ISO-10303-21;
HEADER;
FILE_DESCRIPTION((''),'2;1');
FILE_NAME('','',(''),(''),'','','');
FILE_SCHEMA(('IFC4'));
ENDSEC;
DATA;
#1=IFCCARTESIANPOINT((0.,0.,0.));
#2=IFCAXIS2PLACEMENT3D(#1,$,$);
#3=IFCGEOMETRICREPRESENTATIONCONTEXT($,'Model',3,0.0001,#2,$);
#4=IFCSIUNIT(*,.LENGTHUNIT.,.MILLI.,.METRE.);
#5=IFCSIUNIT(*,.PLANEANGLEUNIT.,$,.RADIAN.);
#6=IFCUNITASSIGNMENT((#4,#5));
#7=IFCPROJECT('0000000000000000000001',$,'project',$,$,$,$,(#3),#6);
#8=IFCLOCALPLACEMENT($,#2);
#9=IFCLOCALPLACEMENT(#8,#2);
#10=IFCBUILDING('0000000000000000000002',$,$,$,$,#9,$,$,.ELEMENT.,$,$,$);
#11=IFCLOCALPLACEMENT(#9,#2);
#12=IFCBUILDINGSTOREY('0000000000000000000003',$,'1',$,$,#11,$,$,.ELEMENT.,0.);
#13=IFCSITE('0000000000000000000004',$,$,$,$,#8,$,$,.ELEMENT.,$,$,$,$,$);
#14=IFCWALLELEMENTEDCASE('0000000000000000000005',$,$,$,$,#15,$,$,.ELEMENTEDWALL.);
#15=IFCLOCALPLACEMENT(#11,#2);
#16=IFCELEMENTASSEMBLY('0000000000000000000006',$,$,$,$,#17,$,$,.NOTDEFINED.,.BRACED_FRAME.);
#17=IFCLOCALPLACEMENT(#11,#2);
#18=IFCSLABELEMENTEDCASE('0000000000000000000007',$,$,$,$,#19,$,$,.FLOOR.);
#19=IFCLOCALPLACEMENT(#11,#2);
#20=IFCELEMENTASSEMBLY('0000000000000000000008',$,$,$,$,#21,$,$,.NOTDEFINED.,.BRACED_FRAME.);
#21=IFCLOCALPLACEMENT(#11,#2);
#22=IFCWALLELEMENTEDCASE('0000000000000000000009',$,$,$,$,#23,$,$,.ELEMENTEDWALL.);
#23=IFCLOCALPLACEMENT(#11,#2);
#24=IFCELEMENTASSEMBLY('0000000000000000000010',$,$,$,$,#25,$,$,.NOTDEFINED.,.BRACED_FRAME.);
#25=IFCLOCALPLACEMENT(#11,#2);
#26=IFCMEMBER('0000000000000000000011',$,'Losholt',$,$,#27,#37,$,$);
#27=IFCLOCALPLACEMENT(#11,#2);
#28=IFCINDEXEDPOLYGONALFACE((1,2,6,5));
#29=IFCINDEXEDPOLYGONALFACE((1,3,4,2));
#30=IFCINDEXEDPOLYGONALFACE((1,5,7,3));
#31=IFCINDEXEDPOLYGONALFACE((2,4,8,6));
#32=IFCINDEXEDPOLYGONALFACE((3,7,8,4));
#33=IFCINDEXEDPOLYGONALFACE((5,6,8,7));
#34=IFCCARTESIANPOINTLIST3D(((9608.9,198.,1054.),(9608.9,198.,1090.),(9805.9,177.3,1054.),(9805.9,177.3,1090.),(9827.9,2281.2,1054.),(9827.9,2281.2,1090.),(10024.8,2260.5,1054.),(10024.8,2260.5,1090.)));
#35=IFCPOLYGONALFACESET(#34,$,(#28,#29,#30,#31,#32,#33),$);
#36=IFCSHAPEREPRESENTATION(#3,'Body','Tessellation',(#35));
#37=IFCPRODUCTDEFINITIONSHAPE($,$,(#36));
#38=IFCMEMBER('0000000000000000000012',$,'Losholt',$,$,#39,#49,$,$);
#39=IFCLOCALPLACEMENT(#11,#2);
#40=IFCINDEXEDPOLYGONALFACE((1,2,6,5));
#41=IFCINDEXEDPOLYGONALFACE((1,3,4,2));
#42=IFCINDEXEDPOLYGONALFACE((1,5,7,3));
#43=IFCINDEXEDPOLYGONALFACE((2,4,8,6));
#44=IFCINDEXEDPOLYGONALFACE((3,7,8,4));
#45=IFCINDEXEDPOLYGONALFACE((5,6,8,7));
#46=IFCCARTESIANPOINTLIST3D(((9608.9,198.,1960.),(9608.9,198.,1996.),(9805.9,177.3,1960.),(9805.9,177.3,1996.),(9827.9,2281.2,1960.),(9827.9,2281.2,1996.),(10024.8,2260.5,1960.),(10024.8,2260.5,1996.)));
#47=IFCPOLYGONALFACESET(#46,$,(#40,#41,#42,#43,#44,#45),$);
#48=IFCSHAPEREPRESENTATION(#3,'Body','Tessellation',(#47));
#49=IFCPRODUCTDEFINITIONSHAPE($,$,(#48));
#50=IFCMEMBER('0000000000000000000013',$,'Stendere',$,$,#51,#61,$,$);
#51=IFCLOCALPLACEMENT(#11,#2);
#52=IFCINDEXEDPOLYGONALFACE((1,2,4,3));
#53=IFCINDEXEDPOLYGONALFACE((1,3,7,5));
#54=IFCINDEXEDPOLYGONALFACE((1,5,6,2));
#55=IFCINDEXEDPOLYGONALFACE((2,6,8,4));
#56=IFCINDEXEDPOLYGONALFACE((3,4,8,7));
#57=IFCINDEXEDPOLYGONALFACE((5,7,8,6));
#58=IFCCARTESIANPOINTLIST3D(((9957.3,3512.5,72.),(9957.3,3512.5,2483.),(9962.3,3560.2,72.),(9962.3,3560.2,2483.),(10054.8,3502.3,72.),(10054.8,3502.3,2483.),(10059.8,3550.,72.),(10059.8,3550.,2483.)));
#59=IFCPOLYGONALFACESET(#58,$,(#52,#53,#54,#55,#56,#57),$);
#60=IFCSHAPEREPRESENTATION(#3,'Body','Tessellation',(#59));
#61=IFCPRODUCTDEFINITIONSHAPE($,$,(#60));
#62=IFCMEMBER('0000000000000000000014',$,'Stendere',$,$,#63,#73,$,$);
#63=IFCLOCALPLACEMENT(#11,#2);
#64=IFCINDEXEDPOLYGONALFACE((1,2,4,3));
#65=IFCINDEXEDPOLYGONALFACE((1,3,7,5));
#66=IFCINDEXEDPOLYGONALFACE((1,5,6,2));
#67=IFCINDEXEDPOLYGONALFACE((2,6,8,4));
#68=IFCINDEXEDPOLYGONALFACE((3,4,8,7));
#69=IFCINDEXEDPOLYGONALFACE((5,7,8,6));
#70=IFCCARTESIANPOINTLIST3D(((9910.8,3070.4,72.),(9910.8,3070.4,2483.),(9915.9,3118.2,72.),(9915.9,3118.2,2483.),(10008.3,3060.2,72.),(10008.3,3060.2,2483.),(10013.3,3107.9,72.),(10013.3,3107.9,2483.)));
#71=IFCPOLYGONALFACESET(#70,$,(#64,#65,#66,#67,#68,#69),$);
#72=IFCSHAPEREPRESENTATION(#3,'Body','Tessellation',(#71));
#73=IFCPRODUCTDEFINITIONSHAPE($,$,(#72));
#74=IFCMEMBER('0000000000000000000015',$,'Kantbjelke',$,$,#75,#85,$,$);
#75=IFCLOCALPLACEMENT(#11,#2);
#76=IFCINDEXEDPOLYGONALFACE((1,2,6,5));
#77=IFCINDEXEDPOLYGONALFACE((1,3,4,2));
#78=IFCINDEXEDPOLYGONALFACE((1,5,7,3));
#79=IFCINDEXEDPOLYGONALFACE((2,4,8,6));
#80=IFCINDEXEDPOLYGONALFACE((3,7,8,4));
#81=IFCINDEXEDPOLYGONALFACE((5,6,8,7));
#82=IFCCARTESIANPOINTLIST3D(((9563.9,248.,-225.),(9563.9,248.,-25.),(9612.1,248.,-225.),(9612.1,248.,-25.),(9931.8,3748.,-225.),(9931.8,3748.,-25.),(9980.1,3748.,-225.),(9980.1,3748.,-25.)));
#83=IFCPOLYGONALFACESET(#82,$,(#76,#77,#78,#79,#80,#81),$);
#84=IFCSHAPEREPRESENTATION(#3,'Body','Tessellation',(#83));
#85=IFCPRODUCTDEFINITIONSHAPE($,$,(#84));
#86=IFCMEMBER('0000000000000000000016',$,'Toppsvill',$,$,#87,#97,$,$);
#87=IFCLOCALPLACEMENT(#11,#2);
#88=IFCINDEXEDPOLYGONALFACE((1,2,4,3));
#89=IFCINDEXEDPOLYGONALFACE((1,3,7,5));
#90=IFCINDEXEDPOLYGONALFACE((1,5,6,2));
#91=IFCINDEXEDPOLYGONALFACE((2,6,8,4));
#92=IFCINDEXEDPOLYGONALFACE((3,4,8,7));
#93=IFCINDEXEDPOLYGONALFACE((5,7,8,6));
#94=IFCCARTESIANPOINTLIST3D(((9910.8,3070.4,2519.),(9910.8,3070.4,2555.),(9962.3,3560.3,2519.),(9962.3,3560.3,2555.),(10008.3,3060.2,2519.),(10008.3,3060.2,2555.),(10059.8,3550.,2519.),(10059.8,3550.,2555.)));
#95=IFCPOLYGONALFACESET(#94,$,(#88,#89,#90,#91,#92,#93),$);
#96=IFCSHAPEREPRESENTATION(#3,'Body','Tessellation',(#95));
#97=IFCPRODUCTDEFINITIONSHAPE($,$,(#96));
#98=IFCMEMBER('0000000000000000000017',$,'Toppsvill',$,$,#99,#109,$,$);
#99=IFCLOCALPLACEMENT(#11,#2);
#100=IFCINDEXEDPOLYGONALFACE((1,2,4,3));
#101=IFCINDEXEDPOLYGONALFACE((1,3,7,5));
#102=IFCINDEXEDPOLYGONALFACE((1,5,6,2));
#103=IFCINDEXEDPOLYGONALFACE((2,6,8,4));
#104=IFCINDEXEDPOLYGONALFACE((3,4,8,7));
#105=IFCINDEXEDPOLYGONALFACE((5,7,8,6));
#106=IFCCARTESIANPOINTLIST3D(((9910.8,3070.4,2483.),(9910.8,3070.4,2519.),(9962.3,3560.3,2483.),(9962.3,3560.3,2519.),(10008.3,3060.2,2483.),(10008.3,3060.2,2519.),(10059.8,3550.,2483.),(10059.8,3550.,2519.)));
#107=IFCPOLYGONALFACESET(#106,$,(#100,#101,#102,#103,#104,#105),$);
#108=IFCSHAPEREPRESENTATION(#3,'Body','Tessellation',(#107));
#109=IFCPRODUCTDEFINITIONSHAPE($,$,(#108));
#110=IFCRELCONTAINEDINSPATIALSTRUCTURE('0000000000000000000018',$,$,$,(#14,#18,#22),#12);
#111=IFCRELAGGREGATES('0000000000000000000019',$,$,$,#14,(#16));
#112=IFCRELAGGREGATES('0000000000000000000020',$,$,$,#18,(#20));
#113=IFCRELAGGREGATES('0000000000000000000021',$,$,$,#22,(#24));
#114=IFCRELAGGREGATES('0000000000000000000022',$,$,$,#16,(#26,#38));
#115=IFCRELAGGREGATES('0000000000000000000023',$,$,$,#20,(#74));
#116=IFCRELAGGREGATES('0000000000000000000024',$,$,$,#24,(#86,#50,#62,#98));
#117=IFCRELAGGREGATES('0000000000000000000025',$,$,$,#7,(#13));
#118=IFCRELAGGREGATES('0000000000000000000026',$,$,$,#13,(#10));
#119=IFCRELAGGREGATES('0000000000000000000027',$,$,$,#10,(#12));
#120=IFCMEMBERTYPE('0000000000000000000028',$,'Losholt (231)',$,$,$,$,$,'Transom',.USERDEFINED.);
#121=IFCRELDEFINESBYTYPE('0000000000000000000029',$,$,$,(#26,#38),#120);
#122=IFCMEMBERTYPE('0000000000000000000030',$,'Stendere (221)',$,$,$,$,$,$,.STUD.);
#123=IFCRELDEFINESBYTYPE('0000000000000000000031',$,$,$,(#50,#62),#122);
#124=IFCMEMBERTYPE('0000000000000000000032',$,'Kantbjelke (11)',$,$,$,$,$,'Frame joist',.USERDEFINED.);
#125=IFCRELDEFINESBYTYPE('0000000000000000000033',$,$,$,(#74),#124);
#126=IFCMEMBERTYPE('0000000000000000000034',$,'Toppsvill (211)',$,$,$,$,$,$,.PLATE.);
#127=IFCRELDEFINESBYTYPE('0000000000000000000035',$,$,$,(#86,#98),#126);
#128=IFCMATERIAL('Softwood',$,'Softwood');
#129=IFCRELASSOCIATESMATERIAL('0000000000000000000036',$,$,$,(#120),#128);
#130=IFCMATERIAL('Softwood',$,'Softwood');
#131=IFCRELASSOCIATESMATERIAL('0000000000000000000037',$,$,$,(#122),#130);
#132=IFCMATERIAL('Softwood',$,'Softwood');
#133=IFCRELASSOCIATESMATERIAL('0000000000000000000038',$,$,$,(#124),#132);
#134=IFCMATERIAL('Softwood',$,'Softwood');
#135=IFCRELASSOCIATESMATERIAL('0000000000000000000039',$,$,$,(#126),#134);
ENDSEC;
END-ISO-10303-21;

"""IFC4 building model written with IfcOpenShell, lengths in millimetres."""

from ifc_helpers import new_model, si_unit, frame, origin, place, context, project, spatial, rectangle, extrude, clip, halfspace, material, material_profile, profile_set, type_object, element, aggregate, save


model = new_model("IFC4")

# Units and contexts
model_context = context("Model", 3, precision=0.0001, world=origin())
ifc_project = project(units=[si_unit("LENGTHUNIT", "METRE", prefix="MILLI"), si_unit("PLANEANGLEUNIT", "RADIAN")], contexts=[model_context])

# Site, building, storey
site_placement = place(None, origin())
site = spatial("IfcSite", under=ifc_project, at=site_placement, CompositionType="ELEMENT")
building_placement = place(site_placement, origin())
building = spatial("IfcBuilding", under=site, at=building_placement, CompositionType="ELEMENT")
storey_placement = place(building_placement, origin())
storey = spatial("IfcBuildingStorey", under=building, at=storey_placement, Name="1", CompositionType="ELEMENT", Elevation=0.0)

# Wall, element assembly
wall_1_placement = place(storey_placement, frame((9608.9, 198.0, 535.0), z_axis=(0.994522, -0.104529, 0.0), x_axis=(0.104529, 0.994522, 0.0)))
wall_1 = element("IfcWallElementedCase", 1, at=wall_1_placement, inside=storey, PredefinedType="ELEMENTEDWALL")
assembly_1_placement = place(wall_1_placement, origin())
assembly_1 = element("IfcElementAssembly", 2, at=assembly_1_placement, AssemblyPlace="NOTDEFINED", PredefinedType="BRACED_FRAME")
aggregate(wall_1, [assembly_1])

# Slab, element assembly
slab_placement = place(storey_placement, origin())
slab = element("IfcSlabElementedCase", 3, at=slab_placement, inside=storey, PredefinedType="FLOOR")
assembly_2_placement = place(slab_placement, frame((0.0, 0.0, -225.0)))
assembly_2 = element("IfcElementAssembly", 4, at=assembly_2_placement, AssemblyPlace="NOTDEFINED", PredefinedType="BRACED_FRAME")
aggregate(slab, [assembly_2])

# Wall, element assembly
wall_2_placement = place(storey_placement, frame((9910.8, 3070.4, 0.0), z_axis=(0.994522, -0.104529, 0.0), x_axis=(0.104529, 0.994522, 0.0)))
wall_2 = element("IfcWallElementedCase", 5, at=wall_2_placement, inside=storey, PredefinedType="ELEMENTEDWALL")
assembly_3_placement = place(wall_2_placement, origin())
assembly_3 = element("IfcElementAssembly", 6, at=assembly_3_placement, AssemblyPlace="NOTDEFINED", PredefinedType="BRACED_FRAME")
aggregate(wall_2, [assembly_3])

# Members
ifc_material_1 = material(Name="Softwood", Category="Softwood")
ifc_material_profile_1 = material_profile(ifc_material_1, rectangle(XDim=36.0, YDim=198.0), Name="Losholt (231)")
ifc_profile_set_1 = profile_set([ifc_material_profile_1])
member_type_1 = type_object("IfcMemberType", Name="Losholt (231)", ElementType="Transom", PredefinedType="USERDEFINED", material=ifc_profile_set_1)
member_1_placement = place(assembly_1_placement, frame((0.0, 537.0, 0.0), z_axis=(1.0, 0.0, 0.0), x_axis=(0.0, 1.0, 0.0)))
member_1 = element("IfcMember", 7, at=member_1_placement, type_object=member_type_1, Name="Losholt", context=model_context, shape_type="SweptSolid", body=[
    extrude(rectangle(XDim=36.0, YDim=198.0), frame((0.0, 99.0, 0.0)), (0.0, 0.0, 1.0), 2094.7),
])
member_2_placement = place(assembly_1_placement, frame((0.0, 1443.0, 0.0), z_axis=(1.0, 0.0, 0.0), x_axis=(0.0, 1.0, 0.0)))
member_2 = element("IfcMember", 8, at=member_2_placement, type_object=member_type_1, Name="Losholt", context=model_context, shape_type="SweptSolid", body=[
    extrude(rectangle(XDim=36.0, YDim=198.0), frame((0.0, 99.0, 0.0)), (0.0, 0.0, 1.0), 2094.7),
])
ifc_material_2 = material(Name="Softwood", Category="Softwood")
ifc_material_profile_2 = material_profile(ifc_material_2, rectangle(XDim=48.0, YDim=98.0), Name="Stendere (221)")
ifc_profile_set_2 = profile_set([ifc_material_profile_2])
member_type_2 = type_object("IfcMemberType", Name="Stendere (221)", PredefinedType="STUD", material=ifc_profile_set_2)
member_3_placement = place(assembly_3_placement, frame((468.5, 72.0, 0.0), z_axis=(0.0, 1.0, 0.0), x_axis=(-1.0, 0.0, 0.0)))
member_3 = element("IfcMember", 9, at=member_3_placement, type_object=member_type_2, Name="Stendere", context=model_context, shape_type="SweptSolid", body=[
    extrude(rectangle(XDim=48.0, YDim=98.0), frame((0.0, 49.0, 0.0)), (0.0, 0.0, 1.0), 2411.0),
])
member_4_placement = place(assembly_3_placement, frame((24.0, 72.0, 0.0), z_axis=(0.0, 1.0, 0.0), x_axis=(-1.0, 0.0, 0.0)))
member_4 = element("IfcMember", 10, at=member_4_placement, type_object=member_type_2, Name="Stendere", context=model_context, shape_type="SweptSolid", body=[
    extrude(rectangle(XDim=48.0, YDim=98.0), frame((0.0, 49.0, 0.0)), (0.0, 0.0, 1.0), 2411.0),
])
aggregate(assembly_1, [member_1, member_2])

# Members
ifc_material_3 = material(Name="Softwood", Category="Softwood")
ifc_material_profile_3 = material_profile(ifc_material_3, rectangle(XDim=48.0, YDim=200.0), Name="Kantbjelke (11)")
ifc_profile_set_3 = profile_set([ifc_material_profile_3])
member_type_3 = type_object("IfcMemberType", Name="Kantbjelke (11)", ElementType="Frame joist", PredefinedType="USERDEFINED", material=ifc_profile_set_3)
member_5_placement = place(assembly_2_placement, frame((9588.0, 248.0, 0.0), z_axis=(0.104553, 0.994519, 0.0), x_axis=(-0.994519, 0.104553, 0.0)))
member_5 = element("IfcMember", 11, at=member_5_placement, type_object=member_type_3, Name="Kantbjelke", context=model_context, shape_type="Clipping", body=[
    clip(clip(extrude(rectangle(XDim=48.0, YDim=200.0), frame((0.0, 100.0, -2.5)), (0.0, 0.0, 1.0), 3524.3), halfspace(frame((0.0, 100.0, 0.0), z_axis=(0.104553, 0.0, 0.994519), x_axis=(0.994519, 0.0, -0.104553)), True)), halfspace(frame((0.0, 100.0, 3519.3), z_axis=(0.104553, 0.0, 0.994519), x_axis=(0.994519, 0.0, -0.104553)), False)),
])
aggregate(assembly_2, [member_5])
ifc_material_4 = material(Name="Softwood", Category="Softwood")
ifc_material_profile_4 = material_profile(ifc_material_4, rectangle(XDim=36.0, YDim=98.0), Name="Toppsvill (211)")
ifc_profile_set_4 = profile_set([ifc_material_profile_4])
member_type_4 = type_object("IfcMemberType", Name="Toppsvill (211)", PredefinedType="PLATE", material=ifc_profile_set_4)
member_6_placement = place(assembly_3_placement, frame((0.0, 2537.0, 0.0), z_axis=(1.0, 0.0, 0.0), x_axis=(0.0, 1.0, 0.0)))
member_6 = element("IfcMember", 12, at=member_6_placement, type_object=member_type_4, Name="Toppsvill", context=model_context, shape_type="SweptSolid", body=[
    extrude(rectangle(XDim=36.0, YDim=98.0), frame((0.0, 49.0, 0.0)), (0.0, 0.0, 1.0), 492.5),
])
member_7_placement = place(assembly_3_placement, frame((0.0, 2501.0, 0.0), z_axis=(1.0, 0.0, 0.0), x_axis=(0.0, 1.0, 0.0)))
member_7 = element("IfcMember", 13, at=member_7_placement, type_object=member_type_4, Name="Toppsvill", context=model_context, shape_type="Clipping", body=[
    clip(clip(extrude(rectangle(XDim=36.0, YDim=98.0), frame((0.0, 49.0, 0.0)), (0.0, 0.0, 1.0), 492.5), halfspace(frame((0.0, 49.0, 0.0)), True)), halfspace(frame((0.0, 49.0, 492.5)), False)),
])
aggregate(assembly_3, [member_6, member_3, member_4, member_7])

save(model, "model.ifc")
